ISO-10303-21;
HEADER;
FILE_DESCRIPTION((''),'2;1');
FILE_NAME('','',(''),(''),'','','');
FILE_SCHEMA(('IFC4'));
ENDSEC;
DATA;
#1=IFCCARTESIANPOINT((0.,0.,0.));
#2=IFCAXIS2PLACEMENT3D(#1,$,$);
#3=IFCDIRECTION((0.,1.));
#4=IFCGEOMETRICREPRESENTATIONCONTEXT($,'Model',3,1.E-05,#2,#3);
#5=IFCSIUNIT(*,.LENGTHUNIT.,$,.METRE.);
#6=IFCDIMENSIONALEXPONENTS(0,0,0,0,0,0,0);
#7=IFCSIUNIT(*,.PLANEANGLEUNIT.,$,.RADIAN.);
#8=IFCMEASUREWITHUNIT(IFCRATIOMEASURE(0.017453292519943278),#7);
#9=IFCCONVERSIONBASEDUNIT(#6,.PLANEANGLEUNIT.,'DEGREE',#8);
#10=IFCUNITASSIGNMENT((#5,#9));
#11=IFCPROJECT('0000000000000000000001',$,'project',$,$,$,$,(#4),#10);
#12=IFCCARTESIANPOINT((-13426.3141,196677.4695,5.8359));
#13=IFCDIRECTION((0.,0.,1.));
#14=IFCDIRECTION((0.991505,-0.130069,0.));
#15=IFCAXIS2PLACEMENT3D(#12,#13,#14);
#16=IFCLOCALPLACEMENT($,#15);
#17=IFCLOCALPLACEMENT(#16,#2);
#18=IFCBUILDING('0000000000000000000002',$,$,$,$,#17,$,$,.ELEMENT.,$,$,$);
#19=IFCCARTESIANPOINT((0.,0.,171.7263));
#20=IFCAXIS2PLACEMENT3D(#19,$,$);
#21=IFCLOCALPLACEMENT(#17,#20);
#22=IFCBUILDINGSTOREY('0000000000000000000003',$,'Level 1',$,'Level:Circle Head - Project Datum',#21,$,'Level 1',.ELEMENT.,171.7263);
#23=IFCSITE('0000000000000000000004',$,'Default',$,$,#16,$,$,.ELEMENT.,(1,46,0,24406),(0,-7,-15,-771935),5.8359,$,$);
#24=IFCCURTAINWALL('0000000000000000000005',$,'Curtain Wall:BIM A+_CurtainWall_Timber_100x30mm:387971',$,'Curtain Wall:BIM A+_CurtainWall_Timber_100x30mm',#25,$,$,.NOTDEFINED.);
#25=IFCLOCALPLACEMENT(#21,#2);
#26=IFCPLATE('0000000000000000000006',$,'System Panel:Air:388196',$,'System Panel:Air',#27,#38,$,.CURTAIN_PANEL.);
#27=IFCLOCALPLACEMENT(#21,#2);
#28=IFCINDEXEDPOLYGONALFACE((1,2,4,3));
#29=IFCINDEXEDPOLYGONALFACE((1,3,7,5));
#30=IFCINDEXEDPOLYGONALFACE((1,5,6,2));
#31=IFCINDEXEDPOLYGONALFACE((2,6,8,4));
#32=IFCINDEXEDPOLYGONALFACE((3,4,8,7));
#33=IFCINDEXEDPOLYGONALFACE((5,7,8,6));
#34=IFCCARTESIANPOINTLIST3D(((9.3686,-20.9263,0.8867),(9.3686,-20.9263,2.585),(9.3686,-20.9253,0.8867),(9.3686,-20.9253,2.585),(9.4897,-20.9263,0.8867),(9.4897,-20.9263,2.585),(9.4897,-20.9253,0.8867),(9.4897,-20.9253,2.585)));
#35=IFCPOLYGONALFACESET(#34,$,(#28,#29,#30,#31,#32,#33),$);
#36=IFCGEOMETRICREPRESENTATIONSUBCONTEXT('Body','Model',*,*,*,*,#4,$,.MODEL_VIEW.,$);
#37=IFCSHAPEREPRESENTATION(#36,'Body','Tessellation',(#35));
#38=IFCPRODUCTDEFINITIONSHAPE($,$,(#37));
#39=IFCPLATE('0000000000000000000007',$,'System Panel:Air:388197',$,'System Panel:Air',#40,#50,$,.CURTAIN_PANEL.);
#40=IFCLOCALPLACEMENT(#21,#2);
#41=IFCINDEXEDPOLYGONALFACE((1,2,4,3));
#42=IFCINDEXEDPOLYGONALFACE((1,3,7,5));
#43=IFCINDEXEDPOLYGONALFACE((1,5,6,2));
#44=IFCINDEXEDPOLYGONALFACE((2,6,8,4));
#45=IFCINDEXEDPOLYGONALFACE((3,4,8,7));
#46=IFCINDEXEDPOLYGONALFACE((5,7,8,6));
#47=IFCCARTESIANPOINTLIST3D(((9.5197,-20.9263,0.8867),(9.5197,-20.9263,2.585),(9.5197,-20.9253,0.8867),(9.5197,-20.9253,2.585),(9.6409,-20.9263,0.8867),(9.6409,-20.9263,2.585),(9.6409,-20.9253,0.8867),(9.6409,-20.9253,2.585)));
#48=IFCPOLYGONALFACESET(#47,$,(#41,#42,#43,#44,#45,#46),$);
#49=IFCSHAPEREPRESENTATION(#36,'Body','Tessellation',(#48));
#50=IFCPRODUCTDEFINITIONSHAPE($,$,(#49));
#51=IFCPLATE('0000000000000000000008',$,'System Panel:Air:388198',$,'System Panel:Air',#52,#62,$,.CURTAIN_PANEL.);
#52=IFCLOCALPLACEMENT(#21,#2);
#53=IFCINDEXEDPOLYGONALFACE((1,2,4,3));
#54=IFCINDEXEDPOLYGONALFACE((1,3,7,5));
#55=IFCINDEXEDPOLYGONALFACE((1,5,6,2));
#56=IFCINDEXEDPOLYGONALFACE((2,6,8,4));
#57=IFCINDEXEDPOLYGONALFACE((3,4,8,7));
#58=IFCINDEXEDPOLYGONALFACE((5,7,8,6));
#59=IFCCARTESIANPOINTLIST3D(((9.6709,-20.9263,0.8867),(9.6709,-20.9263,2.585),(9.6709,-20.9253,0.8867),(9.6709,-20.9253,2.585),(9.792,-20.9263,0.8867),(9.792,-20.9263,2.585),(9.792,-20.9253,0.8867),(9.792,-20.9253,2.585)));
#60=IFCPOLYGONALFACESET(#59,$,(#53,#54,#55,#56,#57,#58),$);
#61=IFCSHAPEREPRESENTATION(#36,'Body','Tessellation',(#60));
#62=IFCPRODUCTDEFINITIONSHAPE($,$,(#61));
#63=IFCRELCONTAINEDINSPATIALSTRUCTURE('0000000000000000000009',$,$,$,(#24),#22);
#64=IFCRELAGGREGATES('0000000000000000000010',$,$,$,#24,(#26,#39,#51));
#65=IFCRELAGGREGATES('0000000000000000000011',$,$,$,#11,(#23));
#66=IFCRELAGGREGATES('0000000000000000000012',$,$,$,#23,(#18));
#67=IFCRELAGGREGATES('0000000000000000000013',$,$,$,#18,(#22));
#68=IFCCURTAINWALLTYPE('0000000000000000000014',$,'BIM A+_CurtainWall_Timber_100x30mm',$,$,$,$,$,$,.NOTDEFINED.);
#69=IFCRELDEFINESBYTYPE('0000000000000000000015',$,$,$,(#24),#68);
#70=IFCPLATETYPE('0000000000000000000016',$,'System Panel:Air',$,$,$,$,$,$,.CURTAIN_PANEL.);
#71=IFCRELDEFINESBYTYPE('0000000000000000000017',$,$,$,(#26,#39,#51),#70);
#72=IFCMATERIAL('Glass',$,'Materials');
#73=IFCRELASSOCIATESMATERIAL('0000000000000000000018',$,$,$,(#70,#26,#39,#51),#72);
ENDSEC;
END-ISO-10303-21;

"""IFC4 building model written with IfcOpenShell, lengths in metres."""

from ifc_helpers import new_model, entity, si_unit, converted_unit, direction, frame, origin, place, context, subcontext, project, spatial, indexed_curve, outline, extrude, source, transform, mapped, material, type_object, type_shapes, element, aggregate, save


model = new_model("IFC4")

# Units and contexts
model_context = context("Model", 3, precision=1e-05, world=origin(), true_north=direction((0.0, 1.0)))
body_context = subcontext(model_context, "Body", "Model", "MODEL_VIEW")
ifc_project = project(units=[si_unit("LENGTHUNIT", "METRE"), converted_unit("PLANEANGLEUNIT", "DEGREE", entity("IfcRatioMeasure", 0.017453292519943278), si_unit("PLANEANGLEUNIT", "RADIAN"), dimensions=[0, 0, 0, 0, 0, 0, 0])], contexts=[model_context])

# Site, building, storey
site_placement = place(None, frame((-13426.3141, 196677.4695, 5.8359), z_axis=(0.0, 0.0, 1.0), x_axis=(0.991505, -0.130069, 0.0)))
site = spatial("IfcSite", under=ifc_project, at=site_placement, Name="Default", CompositionType="ELEMENT", RefLatitude=(1, 46, 0, 24406), RefLongitude=(0, -7, -15, -771935), RefElevation=5.8359)
building_placement = place(site_placement, origin())
building = spatial("IfcBuilding", under=site, at=building_placement, CompositionType="ELEMENT")
storey_placement = place(building_placement, frame((0.0, 0.0, 171.7263)))
storey = spatial("IfcBuildingStorey", under=building, at=storey_placement, Name="Level 1", ObjectType="Level:Circle Head - Project Datum", LongName="Level 1", CompositionType="ELEMENT", Elevation=171.7263)

# Curtain wall
curtain_wall_type_1 = type_object("IfcCurtainWallType", Name="BIM A+_CurtainWall_Timber_100x30mm", PredefinedType="NOTDEFINED")
curtain_wall_1_placement = place(storey_placement, frame((0.0, 0.0, -171.7263)))
curtain_wall_1 = element("IfcCurtainWall", 1, at=curtain_wall_1_placement, inside=storey, type_object=curtain_wall_type_1, Name="Curtain Wall:BIM A+_CurtainWall_Timber_100x30mm:387971", ObjectType="Curtain Wall:BIM A+_CurtainWall_Timber_100x30mm", PredefinedType="NOTDEFINED")

# Plates
ifc_material_1 = material(Name="Glass", Category="Materials")
plate_type_1 = type_object("IfcPlateType", Name="System Panel:Air", PredefinedType="CURTAIN_PANEL", material=ifc_material_1)
shared_shape_1 = source(origin(), body_context, "Body", "SweptSolid", [
    extrude(outline(indexed_curve([(-0.0005, -0.0606), (0.0005, -0.0606), (0.0005, 0.0606), (-0.0005, 0.0606), (-0.0005, -0.0606)], self_intersect=False)), frame((0.0, 0.0, 0.0), z_axis=(0.0, 0.0, 1.0), x_axis=(0.0, 1.0, 0.0)), (0.0, 0.0, 1.0), 1.6983),
])
type_shapes(plate_type_1, [shared_shape_1])
plate_1_placement = place(curtain_wall_1_placement, frame((9.4291, -20.9258, 172.613)))
plate_1 = element("IfcPlate", 2, at=plate_1_placement, type_object=plate_type_1, material=ifc_material_1, Name="System Panel:Air:388196", ObjectType="System Panel:Air", PredefinedType="CURTAIN_PANEL", context=body_context, shape_type="MappedRepresentation", body=[
    mapped(shared_shape_1, transform((0.0, 0.0, 0.0), scale=1.0)),
])
plate_2_placement = place(curtain_wall_1_placement, frame((9.5803, -20.9258, 172.613)))
plate_2 = element("IfcPlate", 3, at=plate_2_placement, type_object=plate_type_1, material=ifc_material_1, Name="System Panel:Air:388197", ObjectType="System Panel:Air", PredefinedType="CURTAIN_PANEL", context=body_context, shape_type="MappedRepresentation", body=[
    mapped(shared_shape_1, transform((0.0, 0.0, 0.0), scale=1.0)),
])
plate_3_placement = place(curtain_wall_1_placement, frame((9.7315, -20.9258, 172.613)))
plate_3 = element("IfcPlate", 4, at=plate_3_placement, type_object=plate_type_1, material=ifc_material_1, Name="System Panel:Air:388198", ObjectType="System Panel:Air", PredefinedType="CURTAIN_PANEL", context=body_context, shape_type="MappedRepresentation", body=[
    mapped(shared_shape_1, transform((0.0, 0.0, 0.0), scale=1.0)),
])
aggregate(curtain_wall_1, [plate_1, plate_2, plate_3])

save(model, "model.ifc")
